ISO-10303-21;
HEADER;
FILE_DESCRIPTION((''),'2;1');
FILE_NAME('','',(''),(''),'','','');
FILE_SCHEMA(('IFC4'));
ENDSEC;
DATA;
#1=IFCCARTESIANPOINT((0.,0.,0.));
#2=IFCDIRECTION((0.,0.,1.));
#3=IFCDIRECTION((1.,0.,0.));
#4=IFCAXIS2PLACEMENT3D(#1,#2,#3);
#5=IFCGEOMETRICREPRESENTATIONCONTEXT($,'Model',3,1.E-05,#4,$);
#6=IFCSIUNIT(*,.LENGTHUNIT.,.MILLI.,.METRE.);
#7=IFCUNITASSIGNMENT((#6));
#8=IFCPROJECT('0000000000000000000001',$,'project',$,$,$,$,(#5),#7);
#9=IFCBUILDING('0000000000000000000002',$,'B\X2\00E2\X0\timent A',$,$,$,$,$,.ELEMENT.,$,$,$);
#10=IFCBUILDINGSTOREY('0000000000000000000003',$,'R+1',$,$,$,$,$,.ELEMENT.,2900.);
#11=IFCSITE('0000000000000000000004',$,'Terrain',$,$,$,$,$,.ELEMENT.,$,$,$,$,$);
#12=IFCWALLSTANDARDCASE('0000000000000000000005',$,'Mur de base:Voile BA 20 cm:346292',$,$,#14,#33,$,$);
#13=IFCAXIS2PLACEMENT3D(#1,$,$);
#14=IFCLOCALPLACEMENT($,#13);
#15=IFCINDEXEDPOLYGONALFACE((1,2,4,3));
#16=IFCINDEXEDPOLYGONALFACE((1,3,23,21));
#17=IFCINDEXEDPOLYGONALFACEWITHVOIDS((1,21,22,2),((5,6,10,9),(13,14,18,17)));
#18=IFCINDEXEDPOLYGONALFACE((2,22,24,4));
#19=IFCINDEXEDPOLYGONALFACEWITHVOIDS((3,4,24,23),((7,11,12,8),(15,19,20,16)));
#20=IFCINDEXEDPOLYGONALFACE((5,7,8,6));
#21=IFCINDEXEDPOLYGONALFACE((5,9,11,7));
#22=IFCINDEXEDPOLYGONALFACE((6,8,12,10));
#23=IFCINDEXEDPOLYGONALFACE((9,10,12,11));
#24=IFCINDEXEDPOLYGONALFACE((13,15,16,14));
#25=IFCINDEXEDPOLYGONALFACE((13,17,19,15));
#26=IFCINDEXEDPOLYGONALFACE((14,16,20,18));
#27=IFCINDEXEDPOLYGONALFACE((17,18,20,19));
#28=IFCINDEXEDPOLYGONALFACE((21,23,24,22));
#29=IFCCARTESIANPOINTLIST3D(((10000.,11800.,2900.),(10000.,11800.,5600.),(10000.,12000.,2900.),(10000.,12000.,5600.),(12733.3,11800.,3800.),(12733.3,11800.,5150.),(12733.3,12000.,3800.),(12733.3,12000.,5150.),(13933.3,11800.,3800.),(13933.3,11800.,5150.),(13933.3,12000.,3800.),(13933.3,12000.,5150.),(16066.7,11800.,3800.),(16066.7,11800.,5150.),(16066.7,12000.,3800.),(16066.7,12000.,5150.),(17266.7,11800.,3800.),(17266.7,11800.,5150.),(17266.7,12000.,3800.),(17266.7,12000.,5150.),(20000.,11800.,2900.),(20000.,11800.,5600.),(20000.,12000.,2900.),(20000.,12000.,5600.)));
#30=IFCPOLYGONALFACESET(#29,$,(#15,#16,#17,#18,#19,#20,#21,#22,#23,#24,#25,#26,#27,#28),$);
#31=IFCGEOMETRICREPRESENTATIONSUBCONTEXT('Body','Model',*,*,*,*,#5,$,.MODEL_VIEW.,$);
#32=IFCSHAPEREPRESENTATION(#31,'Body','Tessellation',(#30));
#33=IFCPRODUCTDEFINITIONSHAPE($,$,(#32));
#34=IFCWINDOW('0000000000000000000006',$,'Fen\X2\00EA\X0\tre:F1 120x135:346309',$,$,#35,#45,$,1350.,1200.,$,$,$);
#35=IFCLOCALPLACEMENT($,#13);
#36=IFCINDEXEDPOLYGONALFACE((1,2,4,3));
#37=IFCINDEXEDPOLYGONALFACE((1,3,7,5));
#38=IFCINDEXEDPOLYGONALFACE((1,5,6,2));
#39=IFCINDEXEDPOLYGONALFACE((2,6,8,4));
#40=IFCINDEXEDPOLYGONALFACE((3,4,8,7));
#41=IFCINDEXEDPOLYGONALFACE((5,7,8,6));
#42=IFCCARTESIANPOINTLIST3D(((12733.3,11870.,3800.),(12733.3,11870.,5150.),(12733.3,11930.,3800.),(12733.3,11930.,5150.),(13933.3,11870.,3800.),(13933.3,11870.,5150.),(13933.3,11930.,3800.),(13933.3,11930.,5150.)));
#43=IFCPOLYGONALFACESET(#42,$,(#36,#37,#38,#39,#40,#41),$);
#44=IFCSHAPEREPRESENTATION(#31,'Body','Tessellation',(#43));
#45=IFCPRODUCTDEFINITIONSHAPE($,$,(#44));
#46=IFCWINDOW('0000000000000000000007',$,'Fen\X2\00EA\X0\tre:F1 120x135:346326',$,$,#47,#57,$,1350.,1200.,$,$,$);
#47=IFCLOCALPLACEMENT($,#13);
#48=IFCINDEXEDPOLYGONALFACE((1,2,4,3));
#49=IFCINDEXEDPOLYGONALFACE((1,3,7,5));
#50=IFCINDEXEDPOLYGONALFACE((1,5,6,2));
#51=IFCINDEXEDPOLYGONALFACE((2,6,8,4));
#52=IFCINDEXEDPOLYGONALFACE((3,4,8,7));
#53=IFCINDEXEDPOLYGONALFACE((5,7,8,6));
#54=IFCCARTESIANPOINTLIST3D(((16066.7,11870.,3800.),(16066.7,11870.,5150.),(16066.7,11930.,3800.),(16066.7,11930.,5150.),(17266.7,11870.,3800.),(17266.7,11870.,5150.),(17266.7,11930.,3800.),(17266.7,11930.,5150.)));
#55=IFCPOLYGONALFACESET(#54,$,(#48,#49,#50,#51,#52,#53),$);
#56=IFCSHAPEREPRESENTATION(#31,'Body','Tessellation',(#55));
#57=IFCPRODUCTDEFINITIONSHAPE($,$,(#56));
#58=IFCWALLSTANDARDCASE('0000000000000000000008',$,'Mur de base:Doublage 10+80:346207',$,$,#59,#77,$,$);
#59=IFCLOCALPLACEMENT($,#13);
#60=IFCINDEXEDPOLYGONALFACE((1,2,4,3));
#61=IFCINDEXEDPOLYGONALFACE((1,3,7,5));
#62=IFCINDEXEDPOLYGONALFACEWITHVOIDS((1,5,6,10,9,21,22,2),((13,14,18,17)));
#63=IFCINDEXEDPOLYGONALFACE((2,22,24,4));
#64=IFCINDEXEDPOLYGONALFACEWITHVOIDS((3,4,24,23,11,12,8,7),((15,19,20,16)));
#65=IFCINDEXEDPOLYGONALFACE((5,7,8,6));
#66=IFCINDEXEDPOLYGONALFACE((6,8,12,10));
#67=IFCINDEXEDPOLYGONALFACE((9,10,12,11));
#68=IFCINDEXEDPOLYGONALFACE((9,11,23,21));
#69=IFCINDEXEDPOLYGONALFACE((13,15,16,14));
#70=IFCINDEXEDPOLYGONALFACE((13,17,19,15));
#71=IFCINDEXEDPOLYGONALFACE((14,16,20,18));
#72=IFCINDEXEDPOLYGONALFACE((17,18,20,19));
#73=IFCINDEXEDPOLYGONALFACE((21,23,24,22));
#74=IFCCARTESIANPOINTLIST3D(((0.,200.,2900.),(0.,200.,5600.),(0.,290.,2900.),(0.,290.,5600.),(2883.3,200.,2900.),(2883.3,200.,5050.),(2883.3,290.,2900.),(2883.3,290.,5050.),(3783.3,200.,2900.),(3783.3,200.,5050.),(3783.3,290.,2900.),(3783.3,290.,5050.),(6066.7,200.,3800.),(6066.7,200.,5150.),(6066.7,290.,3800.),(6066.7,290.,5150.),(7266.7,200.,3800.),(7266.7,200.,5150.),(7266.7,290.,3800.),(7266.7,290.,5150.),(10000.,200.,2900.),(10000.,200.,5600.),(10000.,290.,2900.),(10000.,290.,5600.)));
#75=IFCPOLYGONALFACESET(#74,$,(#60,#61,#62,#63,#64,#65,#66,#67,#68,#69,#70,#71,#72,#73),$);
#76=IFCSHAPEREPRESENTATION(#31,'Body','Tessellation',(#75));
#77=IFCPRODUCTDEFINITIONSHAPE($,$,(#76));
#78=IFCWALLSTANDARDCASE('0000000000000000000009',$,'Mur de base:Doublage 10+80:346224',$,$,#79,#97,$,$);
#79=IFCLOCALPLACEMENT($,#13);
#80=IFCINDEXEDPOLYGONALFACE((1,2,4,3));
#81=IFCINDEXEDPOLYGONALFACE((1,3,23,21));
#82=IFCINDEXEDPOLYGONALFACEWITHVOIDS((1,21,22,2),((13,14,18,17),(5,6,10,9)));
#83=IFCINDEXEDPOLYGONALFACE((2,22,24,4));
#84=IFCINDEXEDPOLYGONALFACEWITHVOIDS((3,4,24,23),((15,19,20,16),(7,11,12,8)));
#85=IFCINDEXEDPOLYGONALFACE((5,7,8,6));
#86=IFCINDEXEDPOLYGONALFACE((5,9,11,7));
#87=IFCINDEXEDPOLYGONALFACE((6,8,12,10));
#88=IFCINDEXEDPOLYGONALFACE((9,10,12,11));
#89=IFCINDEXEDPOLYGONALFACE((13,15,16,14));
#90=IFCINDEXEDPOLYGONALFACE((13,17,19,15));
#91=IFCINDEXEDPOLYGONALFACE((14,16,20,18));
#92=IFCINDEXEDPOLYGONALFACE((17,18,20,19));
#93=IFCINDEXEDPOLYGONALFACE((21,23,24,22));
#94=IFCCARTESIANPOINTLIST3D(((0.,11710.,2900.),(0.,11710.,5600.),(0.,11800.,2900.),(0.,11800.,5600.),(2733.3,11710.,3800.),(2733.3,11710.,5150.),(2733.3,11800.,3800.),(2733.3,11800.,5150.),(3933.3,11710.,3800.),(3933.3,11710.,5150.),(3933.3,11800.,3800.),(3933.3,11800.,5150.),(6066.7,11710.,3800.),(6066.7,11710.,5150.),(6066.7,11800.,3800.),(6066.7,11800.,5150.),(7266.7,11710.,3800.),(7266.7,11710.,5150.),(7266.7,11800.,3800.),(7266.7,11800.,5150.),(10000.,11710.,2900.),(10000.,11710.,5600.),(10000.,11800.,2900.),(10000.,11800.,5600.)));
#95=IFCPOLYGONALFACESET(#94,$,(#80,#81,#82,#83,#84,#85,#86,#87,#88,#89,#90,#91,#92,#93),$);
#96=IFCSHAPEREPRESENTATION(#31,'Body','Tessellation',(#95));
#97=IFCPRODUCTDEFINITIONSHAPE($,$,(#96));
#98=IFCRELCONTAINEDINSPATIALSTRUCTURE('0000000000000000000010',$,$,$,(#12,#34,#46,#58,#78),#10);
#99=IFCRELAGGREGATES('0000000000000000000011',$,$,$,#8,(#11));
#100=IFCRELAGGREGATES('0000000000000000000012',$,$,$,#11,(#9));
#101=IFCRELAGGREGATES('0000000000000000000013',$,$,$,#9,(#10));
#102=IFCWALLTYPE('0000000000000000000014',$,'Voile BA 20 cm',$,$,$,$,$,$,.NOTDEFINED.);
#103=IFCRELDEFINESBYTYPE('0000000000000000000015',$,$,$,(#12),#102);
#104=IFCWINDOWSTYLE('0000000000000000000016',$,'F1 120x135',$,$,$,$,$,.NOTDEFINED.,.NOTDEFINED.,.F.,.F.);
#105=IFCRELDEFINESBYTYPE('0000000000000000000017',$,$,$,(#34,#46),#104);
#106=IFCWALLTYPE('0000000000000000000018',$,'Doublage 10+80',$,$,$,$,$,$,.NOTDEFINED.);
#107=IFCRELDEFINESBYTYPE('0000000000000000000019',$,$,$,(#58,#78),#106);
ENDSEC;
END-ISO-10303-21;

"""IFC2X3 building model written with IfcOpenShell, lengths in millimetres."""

from ifc_helpers import new_model, si_unit, frame, frame_2d, origin_with_axes, place, context, subcontext, project, spatial, rectangle, extrude, type_object, element, fill, save


model = new_model("IFC2X3")

# Units and contexts
model_context = context("Model", 3, precision=1e-05, world=origin_with_axes())
body_context = subcontext(model_context, "Body", "Model", "MODEL_VIEW")
ifc_project = project(units=[si_unit("LENGTHUNIT", "METRE", prefix="MILLI")], contexts=[model_context])

# Site, building, storey
site = spatial("IfcSite", under=ifc_project, Name="Terrain", CompositionType="ELEMENT")
building = spatial("IfcBuilding", under=site, Name="Bâtiment A", CompositionType="ELEMENT")
storey = spatial("IfcBuildingStorey", under=building, Name="R+1", CompositionType="ELEMENT", Elevation=2900.0)

# Shared definitions
wall_type_1 = type_object("IfcWallType", Name="Voile BA 20 cm", PredefinedType="NOTDEFINED")
window_style = type_object("IfcWindowStyle", Name="F1 120x135", ConstructionType="NOTDEFINED", OperationType="NOTDEFINED", ParameterTakesPrecedence=False, Sizeable=False)

# Wall, openings, windows
wall_1_placement = place(None, origin_with_axes())
wall_1 = element("IfcWallStandardCase", 1, at=wall_1_placement, inside=storey, type_object=wall_type_1, Name="Mur de base:Voile BA 20 cm:346292", context=body_context, shape_type="SweptSolid", body=[
    extrude(rectangle(XDim=10000.0, YDim=200.0, at=frame_2d((15000.0, 11900.0))), frame((0.0, 0.0, 2900.0), z_axis=(0.0, 0.0, 1.0), x_axis=(1.0, 0.0, 0.0)), (0.0, 0.0, 1.0), 2700.0),
])
opening_1_placement = place(None, origin_with_axes())
opening_1 = element("IfcOpeningElement", 2, at=opening_1_placement, cuts=wall_1, context=body_context, shape_type="SweptSolid", body=[
    extrude(rectangle(XDim=1200.0, YDim=320.0, at=frame_2d((13333.3, 11900.0))), frame((0.0, 0.0, 3800.0), z_axis=(0.0, 0.0, 1.0), x_axis=(1.0, 0.0, 0.0)), (0.0, 0.0, 1.0), 1350.0),
])
opening_2_placement = place(None, origin_with_axes())
opening_2 = element("IfcOpeningElement", 3, at=opening_2_placement, cuts=wall_1, context=body_context, shape_type="SweptSolid", body=[
    extrude(rectangle(XDim=1200.0, YDim=320.0, at=frame_2d((16666.7, 11900.0))), frame((0.0, 0.0, 3800.0), z_axis=(0.0, 0.0, 1.0), x_axis=(1.0, 0.0, 0.0)), (0.0, 0.0, 1.0), 1350.0),
])
window_1_placement = place(None, origin_with_axes())
window_1 = element("IfcWindow", 4, at=window_1_placement, inside=storey, type_object=window_style, Name="Fenêtre:F1 120x135:346309", OverallHeight=1350.0, OverallWidth=1200.0, context=body_context, shape_type="SweptSolid", body=[
    extrude(rectangle(XDim=1200.0, YDim=60.0, at=frame_2d((13333.3, 11900.0))), frame((0.0, 0.0, 3800.0), z_axis=(0.0, 0.0, 1.0), x_axis=(1.0, 0.0, 0.0)), (0.0, 0.0, 1.0), 1350.0),
])
fill(opening_1, window_1)
window_2_placement = place(None, origin_with_axes())
window_2 = element("IfcWindow", 5, at=window_2_placement, inside=storey, type_object=window_style, Name="Fenêtre:F1 120x135:346326", OverallHeight=1350.0, OverallWidth=1200.0, context=body_context, shape_type="SweptSolid", body=[
    extrude(rectangle(XDim=1200.0, YDim=60.0, at=frame_2d((16666.7, 11900.0))), frame((0.0, 0.0, 3800.0), z_axis=(0.0, 0.0, 1.0), x_axis=(1.0, 0.0, 0.0)), (0.0, 0.0, 1.0), 1350.0),
])
fill(opening_2, window_2)

# Walls, openings
wall_type_2 = type_object("IfcWallType", Name="Doublage 10+80", PredefinedType="NOTDEFINED")
wall_2_placement = place(None, origin_with_axes())
wall_2 = element("IfcWallStandardCase", 6, at=wall_2_placement, inside=storey, type_object=wall_type_2, Name="Mur de base:Doublage 10+80:346207", context=body_context, shape_type="SweptSolid", body=[
    extrude(rectangle(XDim=10000.0, YDim=90.0, at=frame_2d((5000.0, 245.0))), frame((0.0, 0.0, 2900.0), z_axis=(0.0, 0.0, 1.0), x_axis=(1.0, 0.0, 0.0)), (0.0, 0.0, 1.0), 2700.0),
])
opening_3_placement = place(None, origin_with_axes())
element("IfcOpeningElement", 7, at=opening_3_placement, cuts=wall_2, context=body_context, shape_type="SweptSolid", body=[
    extrude(rectangle(XDim=900.0, YDim=210.0, at=frame_2d((3333.3, 245.0))), frame((0.0, 0.0, 2900.0), z_axis=(0.0, 0.0, 1.0), x_axis=(1.0, 0.0, 0.0)), (0.0, 0.0, 1.0), 2150.0),
])
opening_4_placement = place(None, origin_with_axes())
element("IfcOpeningElement", 8, at=opening_4_placement, cuts=wall_2, context=body_context, shape_type="SweptSolid", body=[
    extrude(rectangle(XDim=1200.0, YDim=210.0, at=frame_2d((6666.7, 245.0))), frame((0.0, 0.0, 3800.0), z_axis=(0.0, 0.0, 1.0), x_axis=(1.0, 0.0, 0.0)), (0.0, 0.0, 1.0), 1350.0),
])
wall_3_placement = place(None, origin_with_axes())
wall_3 = element("IfcWallStandardCase", 9, at=wall_3_placement, inside=storey, type_object=wall_type_2, Name="Mur de base:Doublage 10+80:346224", context=body_context, shape_type="SweptSolid", body=[
    extrude(rectangle(XDim=10000.0, YDim=90.0, at=frame_2d((5000.0, 11755.0))), frame((0.0, 0.0, 2900.0), z_axis=(0.0, 0.0, 1.0), x_axis=(1.0, 0.0, 0.0)), (0.0, 0.0, 1.0), 2700.0),
])
opening_5_placement = place(None, origin_with_axes())
element("IfcOpeningElement", 10, at=opening_5_placement, cuts=wall_3, context=body_context, shape_type="SweptSolid", body=[
    extrude(rectangle(XDim=1200.0, YDim=210.0, at=frame_2d((3333.3, 11755.0))), frame((0.0, 0.0, 3800.0), z_axis=(0.0, 0.0, 1.0), x_axis=(1.0, 0.0, 0.0)), (0.0, 0.0, 1.0), 1350.0),
])
opening_6_placement = place(None, origin_with_axes())
element("IfcOpeningElement", 11, at=opening_6_placement, cuts=wall_3, context=body_context, shape_type="SweptSolid", body=[
    extrude(rectangle(XDim=1200.0, YDim=210.0, at=frame_2d((6666.7, 11755.0))), frame((0.0, 0.0, 3800.0), z_axis=(0.0, 0.0, 1.0), x_axis=(1.0, 0.0, 0.0)), (0.0, 0.0, 1.0), 1350.0),
])

save(model, "model.ifc")
